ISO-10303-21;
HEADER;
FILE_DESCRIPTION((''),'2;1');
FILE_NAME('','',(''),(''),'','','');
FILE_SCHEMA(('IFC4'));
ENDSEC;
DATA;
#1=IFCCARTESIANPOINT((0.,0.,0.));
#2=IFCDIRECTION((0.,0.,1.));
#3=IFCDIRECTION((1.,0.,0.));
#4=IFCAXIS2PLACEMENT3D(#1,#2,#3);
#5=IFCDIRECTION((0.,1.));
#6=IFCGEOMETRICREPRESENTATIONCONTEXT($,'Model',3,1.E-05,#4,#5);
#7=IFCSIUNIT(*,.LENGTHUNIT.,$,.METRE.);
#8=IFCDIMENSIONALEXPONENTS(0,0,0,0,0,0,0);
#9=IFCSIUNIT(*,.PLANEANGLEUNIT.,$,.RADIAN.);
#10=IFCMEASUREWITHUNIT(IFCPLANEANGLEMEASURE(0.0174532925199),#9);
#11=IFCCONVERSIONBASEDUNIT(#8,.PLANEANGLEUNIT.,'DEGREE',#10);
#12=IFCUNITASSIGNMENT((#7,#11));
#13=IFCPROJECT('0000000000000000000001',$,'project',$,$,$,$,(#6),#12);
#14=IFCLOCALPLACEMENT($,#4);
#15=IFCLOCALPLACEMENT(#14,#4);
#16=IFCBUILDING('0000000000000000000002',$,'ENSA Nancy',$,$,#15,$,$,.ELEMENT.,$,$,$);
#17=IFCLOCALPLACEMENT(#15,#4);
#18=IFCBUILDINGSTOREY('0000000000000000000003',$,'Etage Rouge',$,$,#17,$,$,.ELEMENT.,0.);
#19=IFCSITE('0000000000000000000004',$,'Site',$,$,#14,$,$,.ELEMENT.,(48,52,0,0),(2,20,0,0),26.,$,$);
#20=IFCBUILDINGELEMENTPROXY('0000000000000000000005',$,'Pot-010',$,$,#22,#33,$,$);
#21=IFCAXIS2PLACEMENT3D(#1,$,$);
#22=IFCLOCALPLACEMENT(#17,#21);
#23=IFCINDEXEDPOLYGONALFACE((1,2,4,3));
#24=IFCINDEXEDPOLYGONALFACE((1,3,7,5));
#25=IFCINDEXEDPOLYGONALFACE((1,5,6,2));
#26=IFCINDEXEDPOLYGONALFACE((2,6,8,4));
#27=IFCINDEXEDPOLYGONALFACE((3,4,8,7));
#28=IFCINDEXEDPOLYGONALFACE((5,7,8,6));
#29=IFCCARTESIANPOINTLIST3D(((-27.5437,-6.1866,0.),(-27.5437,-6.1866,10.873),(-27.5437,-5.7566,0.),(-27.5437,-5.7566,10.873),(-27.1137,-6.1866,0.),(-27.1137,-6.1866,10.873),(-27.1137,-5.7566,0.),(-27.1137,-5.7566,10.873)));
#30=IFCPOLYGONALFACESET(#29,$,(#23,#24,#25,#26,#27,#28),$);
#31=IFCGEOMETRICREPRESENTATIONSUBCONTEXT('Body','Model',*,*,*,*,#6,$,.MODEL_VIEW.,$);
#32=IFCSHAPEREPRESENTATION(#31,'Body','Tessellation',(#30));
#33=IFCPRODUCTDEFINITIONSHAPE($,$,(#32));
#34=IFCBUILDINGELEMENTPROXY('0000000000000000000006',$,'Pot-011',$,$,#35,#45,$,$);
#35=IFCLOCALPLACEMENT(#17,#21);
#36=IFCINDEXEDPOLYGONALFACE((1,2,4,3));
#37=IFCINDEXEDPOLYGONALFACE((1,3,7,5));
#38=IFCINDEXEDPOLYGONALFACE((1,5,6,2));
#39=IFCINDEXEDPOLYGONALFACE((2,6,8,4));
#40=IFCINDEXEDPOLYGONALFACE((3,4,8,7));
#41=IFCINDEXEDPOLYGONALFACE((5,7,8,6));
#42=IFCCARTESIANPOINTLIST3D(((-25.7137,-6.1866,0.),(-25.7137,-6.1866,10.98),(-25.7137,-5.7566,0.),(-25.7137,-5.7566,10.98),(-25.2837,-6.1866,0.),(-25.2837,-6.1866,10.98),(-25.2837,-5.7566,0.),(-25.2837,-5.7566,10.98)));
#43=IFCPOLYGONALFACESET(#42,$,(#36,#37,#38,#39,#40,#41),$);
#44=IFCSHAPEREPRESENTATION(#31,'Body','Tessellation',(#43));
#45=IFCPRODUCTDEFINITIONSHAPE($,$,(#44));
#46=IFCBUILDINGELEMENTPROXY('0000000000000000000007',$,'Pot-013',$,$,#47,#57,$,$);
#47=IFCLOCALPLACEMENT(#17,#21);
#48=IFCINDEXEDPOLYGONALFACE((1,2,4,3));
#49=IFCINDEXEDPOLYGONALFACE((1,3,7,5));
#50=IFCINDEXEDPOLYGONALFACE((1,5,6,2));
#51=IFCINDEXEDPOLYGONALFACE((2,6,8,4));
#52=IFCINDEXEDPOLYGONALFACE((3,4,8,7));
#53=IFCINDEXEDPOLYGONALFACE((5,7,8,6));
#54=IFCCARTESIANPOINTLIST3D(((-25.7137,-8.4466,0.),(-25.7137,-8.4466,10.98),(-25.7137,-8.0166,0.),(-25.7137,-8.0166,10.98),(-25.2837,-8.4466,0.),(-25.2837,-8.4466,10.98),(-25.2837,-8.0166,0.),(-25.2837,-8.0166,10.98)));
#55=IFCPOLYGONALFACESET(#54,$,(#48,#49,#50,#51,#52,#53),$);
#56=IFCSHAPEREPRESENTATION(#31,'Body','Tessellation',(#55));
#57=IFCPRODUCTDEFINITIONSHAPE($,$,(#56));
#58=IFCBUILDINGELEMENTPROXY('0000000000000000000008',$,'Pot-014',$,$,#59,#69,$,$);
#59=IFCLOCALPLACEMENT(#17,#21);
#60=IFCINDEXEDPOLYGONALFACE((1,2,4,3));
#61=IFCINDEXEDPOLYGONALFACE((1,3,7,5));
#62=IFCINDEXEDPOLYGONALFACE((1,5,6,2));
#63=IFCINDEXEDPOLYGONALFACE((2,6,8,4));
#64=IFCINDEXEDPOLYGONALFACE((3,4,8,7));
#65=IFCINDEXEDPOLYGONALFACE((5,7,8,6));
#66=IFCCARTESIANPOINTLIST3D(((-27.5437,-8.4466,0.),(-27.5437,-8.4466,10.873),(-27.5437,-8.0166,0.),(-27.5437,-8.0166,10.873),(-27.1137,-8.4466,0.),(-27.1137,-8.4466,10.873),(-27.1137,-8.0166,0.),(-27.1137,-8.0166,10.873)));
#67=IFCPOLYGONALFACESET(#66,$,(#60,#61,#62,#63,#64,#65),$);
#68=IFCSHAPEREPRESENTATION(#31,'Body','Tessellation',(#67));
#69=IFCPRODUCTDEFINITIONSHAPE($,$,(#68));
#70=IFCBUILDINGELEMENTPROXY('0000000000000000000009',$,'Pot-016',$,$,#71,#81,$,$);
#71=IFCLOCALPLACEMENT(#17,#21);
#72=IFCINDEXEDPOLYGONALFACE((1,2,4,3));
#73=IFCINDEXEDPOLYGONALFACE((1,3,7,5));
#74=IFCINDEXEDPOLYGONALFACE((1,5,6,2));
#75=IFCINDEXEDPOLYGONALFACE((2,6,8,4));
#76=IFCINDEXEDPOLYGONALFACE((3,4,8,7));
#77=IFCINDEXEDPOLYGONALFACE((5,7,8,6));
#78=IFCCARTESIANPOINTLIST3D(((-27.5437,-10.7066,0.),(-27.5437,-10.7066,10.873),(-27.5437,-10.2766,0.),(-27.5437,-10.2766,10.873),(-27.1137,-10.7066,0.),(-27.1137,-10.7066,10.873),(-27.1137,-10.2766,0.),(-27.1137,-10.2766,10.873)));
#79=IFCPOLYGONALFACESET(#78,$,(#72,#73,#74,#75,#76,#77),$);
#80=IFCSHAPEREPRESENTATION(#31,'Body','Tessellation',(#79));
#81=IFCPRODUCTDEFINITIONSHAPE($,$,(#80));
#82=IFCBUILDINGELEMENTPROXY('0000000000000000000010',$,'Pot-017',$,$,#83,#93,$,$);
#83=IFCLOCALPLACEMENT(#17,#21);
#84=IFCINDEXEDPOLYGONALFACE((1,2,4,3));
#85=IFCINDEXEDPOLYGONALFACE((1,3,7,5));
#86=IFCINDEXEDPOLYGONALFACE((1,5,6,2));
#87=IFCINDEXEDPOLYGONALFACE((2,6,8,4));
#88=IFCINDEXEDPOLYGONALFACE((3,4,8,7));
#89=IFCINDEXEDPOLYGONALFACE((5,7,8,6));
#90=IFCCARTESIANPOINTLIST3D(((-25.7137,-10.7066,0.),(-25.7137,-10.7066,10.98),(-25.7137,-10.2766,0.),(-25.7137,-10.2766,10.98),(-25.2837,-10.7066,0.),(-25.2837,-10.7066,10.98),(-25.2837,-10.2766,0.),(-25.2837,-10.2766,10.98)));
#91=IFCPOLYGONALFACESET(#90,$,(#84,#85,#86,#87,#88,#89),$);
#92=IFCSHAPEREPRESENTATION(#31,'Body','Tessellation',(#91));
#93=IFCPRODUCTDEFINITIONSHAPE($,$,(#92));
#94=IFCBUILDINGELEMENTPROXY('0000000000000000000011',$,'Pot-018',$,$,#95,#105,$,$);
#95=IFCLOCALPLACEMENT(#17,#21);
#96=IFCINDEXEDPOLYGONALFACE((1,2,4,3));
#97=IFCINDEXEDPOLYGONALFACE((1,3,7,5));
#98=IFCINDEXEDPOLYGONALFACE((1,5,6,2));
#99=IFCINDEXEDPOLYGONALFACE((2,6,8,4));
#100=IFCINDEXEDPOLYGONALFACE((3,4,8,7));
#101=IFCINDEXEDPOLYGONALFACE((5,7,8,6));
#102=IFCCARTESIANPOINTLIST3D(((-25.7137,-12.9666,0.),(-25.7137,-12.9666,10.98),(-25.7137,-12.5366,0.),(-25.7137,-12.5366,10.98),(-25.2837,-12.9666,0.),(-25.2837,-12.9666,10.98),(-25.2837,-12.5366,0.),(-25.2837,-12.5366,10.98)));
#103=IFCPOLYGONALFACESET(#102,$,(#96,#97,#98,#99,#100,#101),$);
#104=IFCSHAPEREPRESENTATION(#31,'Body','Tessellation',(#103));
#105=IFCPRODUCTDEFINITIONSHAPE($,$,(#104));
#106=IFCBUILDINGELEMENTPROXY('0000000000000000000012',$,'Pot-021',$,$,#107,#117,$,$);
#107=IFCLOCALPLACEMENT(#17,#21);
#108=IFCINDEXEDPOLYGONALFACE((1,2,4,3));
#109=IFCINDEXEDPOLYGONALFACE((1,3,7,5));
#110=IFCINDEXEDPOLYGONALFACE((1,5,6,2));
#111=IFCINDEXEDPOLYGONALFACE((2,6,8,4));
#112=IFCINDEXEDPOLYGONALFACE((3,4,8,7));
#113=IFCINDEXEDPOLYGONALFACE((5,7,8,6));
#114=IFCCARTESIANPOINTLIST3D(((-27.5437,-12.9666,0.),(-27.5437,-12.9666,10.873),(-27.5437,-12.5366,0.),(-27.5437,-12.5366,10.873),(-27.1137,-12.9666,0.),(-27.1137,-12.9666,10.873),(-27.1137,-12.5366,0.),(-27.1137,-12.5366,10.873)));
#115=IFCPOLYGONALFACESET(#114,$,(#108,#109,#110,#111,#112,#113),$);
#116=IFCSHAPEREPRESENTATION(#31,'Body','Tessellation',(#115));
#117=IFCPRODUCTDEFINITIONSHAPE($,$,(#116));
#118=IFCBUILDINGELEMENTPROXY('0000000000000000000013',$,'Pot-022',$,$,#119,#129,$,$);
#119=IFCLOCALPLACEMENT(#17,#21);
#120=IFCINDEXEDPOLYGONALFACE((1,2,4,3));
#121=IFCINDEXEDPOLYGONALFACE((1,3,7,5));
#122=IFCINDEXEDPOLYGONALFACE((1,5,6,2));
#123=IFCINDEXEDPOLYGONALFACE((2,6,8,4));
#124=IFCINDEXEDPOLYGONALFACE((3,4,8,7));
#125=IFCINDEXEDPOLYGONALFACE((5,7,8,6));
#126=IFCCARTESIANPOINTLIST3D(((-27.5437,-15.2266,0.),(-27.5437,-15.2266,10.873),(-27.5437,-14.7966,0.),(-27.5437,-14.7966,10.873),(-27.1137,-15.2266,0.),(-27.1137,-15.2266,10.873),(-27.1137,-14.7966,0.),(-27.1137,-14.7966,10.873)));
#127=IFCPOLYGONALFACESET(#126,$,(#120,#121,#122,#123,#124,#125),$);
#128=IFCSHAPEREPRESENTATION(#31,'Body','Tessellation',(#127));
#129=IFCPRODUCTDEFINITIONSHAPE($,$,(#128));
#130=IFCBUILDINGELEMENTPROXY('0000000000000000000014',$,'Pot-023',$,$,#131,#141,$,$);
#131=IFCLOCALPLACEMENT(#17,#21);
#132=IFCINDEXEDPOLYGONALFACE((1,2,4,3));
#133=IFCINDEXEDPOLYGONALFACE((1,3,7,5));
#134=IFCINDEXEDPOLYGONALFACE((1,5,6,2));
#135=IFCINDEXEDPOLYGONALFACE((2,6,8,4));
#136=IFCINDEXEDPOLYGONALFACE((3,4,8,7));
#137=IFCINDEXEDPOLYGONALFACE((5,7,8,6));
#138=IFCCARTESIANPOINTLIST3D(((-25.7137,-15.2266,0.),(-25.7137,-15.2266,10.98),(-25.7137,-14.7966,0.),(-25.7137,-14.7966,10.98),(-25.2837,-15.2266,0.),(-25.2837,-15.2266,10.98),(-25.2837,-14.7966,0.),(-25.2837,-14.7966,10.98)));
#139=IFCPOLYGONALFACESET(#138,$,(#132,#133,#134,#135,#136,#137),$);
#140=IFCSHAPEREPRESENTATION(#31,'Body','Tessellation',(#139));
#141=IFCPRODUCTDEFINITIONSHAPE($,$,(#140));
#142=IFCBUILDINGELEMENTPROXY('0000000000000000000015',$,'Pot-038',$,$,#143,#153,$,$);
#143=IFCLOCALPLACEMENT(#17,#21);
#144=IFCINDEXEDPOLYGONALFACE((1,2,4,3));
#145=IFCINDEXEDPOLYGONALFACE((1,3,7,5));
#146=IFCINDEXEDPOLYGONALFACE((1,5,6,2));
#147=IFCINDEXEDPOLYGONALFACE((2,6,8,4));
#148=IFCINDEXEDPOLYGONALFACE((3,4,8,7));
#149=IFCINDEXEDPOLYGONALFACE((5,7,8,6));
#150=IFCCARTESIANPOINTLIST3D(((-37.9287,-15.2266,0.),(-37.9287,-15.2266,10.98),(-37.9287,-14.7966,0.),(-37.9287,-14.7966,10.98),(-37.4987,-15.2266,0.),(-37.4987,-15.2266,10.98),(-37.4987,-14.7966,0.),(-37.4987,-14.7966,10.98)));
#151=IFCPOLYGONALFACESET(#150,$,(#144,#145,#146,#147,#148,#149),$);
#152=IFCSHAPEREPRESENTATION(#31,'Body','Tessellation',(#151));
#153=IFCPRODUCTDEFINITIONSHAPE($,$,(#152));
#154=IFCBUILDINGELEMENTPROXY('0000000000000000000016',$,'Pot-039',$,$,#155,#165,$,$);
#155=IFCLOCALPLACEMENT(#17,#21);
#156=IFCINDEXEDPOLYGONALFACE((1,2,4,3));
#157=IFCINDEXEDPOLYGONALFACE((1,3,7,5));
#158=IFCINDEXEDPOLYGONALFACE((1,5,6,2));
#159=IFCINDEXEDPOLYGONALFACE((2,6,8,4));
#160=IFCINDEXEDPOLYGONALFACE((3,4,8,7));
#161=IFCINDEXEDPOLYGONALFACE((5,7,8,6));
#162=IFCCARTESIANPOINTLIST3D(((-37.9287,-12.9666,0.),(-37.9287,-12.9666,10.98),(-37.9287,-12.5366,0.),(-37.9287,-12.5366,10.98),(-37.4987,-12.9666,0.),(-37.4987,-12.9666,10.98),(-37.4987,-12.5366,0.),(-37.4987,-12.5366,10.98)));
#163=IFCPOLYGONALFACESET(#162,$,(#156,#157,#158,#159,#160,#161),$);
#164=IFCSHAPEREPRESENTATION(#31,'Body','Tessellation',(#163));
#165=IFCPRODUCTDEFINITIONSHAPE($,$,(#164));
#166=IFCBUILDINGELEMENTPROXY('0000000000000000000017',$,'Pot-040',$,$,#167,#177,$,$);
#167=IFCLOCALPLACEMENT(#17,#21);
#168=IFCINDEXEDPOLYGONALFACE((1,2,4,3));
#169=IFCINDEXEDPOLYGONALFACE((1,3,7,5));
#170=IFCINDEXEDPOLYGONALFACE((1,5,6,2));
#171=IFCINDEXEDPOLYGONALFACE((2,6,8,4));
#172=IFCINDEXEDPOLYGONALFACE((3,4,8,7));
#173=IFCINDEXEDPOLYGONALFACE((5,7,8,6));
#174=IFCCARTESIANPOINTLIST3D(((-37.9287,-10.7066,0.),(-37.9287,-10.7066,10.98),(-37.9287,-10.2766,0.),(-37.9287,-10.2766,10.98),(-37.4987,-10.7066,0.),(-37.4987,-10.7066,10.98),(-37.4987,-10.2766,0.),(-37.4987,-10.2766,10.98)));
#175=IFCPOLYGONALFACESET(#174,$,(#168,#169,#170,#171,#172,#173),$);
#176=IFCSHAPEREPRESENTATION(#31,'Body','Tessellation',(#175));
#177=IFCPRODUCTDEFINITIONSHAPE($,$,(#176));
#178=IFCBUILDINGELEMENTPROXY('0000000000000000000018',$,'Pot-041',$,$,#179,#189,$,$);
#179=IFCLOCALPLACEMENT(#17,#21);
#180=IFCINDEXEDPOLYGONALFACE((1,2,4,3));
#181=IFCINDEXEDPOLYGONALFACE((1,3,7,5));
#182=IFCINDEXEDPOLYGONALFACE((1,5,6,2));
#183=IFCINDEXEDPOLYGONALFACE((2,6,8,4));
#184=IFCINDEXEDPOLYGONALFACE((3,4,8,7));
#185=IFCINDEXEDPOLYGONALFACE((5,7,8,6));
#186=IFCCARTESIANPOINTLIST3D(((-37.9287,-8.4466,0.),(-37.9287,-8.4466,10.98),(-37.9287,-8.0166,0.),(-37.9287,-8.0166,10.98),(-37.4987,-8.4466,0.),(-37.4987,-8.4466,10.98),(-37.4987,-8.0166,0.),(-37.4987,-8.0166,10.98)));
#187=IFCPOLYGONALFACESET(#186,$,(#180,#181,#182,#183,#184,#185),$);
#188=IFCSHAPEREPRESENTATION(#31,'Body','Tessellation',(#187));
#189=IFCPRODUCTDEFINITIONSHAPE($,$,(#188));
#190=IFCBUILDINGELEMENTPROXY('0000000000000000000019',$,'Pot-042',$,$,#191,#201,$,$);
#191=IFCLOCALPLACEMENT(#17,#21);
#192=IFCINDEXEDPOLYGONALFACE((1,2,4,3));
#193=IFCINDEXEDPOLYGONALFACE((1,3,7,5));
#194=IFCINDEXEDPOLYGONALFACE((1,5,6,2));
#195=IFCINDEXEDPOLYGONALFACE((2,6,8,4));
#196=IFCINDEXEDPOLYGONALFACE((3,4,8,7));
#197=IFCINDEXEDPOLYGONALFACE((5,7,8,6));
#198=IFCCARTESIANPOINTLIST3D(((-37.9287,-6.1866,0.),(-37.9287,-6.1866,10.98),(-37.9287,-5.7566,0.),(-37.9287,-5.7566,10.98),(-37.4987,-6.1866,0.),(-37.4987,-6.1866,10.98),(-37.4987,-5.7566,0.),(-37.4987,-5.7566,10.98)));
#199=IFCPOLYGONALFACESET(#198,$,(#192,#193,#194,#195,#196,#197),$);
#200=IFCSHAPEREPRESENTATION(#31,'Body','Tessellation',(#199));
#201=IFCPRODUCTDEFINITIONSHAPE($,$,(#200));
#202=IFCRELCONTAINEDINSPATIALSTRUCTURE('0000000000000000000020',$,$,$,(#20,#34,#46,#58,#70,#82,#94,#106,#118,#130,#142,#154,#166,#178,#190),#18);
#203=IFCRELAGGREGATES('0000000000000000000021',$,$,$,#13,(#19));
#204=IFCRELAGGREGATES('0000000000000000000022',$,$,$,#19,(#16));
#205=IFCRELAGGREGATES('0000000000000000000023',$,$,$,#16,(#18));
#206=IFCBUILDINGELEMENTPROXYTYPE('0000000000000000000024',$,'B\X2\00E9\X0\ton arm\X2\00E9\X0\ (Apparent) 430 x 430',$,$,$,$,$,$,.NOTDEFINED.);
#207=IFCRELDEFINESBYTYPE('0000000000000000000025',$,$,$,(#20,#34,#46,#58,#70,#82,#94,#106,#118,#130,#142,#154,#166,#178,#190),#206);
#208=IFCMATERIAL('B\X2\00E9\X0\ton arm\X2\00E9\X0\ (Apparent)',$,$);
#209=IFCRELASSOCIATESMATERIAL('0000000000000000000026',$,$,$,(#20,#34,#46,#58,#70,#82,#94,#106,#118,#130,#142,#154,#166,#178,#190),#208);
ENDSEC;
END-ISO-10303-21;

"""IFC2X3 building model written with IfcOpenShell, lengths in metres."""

from ifc_helpers import new_model, entity, si_unit, converted_unit, direction, frame, origin_with_axes, origin_2d_with_axis, place, context, subcontext, project, spatial, rectangle, extrude, material, type_object, element, save


model = new_model("IFC2X3")

# Units and contexts
model_context = context("Model", 3, precision=1e-05, world=origin_with_axes(), true_north=direction((0.0, 1.0)))
body_context = subcontext(model_context, "Body", "Model", "MODEL_VIEW")
ifc_project = project(units=[si_unit("LENGTHUNIT", "METRE"), converted_unit("PLANEANGLEUNIT", "DEGREE", entity("IfcPlaneAngleMeasure", 0.0174532925199), si_unit("PLANEANGLEUNIT", "RADIAN"), dimensions=[0, 0, 0, 0, 0, 0, 0])], contexts=[model_context])

# Site, building, storey
site_placement = place(None, origin_with_axes())
site = spatial("IfcSite", under=ifc_project, at=site_placement, Name="Site", CompositionType="ELEMENT", RefLatitude=(48, 52, 0, 0), RefLongitude=(2, 20, 0, 0), RefElevation=26.0)
building_placement = place(site_placement, origin_with_axes())
building = spatial("IfcBuilding", under=site, at=building_placement, Name="ENSA Nancy", CompositionType="ELEMENT")
storey_placement = place(building_placement, origin_with_axes())
storey = spatial("IfcBuildingStorey", under=building, at=storey_placement, Name="Etage Rouge", CompositionType="ELEMENT", Elevation=0.0)

# Building element proxies
ifc_material_1 = material(Name="Béton armé (Apparent)")
building_element_proxy_type_1 = type_object("IfcBuildingElementProxyType", Name="Béton armé (Apparent) 430 x 430", PredefinedType="NOTDEFINED")
proxy_1_placement = place(storey_placement, frame((-27.3287, -5.9716, 0.0), z_axis=(0.0, 0.0, 1.0), x_axis=(1.0, 0.0, 0.0)))
element("IfcBuildingElementProxy", 1, at=proxy_1_placement, inside=storey, type_object=building_element_proxy_type_1, material=ifc_material_1, Name="Pot-010", context=body_context, shape_type="SweptSolid", body=[
    extrude(rectangle(XDim=0.43, YDim=0.43, at=origin_2d_with_axis()), origin_with_axes(), (0.0, 0.0, 1.0), 10.873),
])
for number, where, z_axis, x_axis, name in (
    (2, (-25.4987, -5.9716, 0.0), (0.0, 0.0, 1.0), (1.0, 0.0, 0.0), "Pot-011"),
    (3, (-25.4987, -8.2316, 0.0), (0.0, 0.0, 1.0), (1.0, 0.0, 0.0), "Pot-013"),
):
    element("IfcBuildingElementProxy", number, at=place(storey_placement, frame(where, z_axis=z_axis, x_axis=x_axis)), inside=storey, type_object=building_element_proxy_type_1, material=ifc_material_1, Name=name, context=body_context, shape_type="SweptSolid", body=[
        extrude(rectangle(XDim=0.43, YDim=0.43, at=origin_2d_with_axis()), origin_with_axes(), (0.0, 0.0, 1.0), 10.98),
    ])
for number, where, z_axis, x_axis, name in (
    (4, (-27.3287, -8.2316, 0.0), (0.0, 0.0, 1.0), (1.0, 0.0, 0.0), "Pot-014"),
    (5, (-27.3287, -10.4916, 0.0), (0.0, 0.0, 1.0), (1.0, 0.0, 0.0), "Pot-016"),
):
    element("IfcBuildingElementProxy", number, at=place(storey_placement, frame(where, z_axis=z_axis, x_axis=x_axis)), inside=storey, type_object=building_element_proxy_type_1, material=ifc_material_1, Name=name, context=body_context, shape_type="SweptSolid", body=[
        extrude(rectangle(XDim=0.43, YDim=0.43, at=origin_2d_with_axis()), origin_with_axes(), (0.0, 0.0, 1.0), 10.873),
    ])
for number, where, z_axis, x_axis, name in (
    (6, (-25.4987, -10.4916, 0.0), (0.0, 0.0, 1.0), (1.0, 0.0, 0.0), "Pot-017"),
    (7, (-25.4987, -12.7516, 0.0), (0.0, 0.0, 1.0), (1.0, 0.0, 0.0), "Pot-018"),
):
    element("IfcBuildingElementProxy", number, at=place(storey_placement, frame(where, z_axis=z_axis, x_axis=x_axis)), inside=storey, type_object=building_element_proxy_type_1, material=ifc_material_1, Name=name, context=body_context, shape_type="SweptSolid", body=[
        extrude(rectangle(XDim=0.43, YDim=0.43, at=origin_2d_with_axis()), origin_with_axes(), (0.0, 0.0, 1.0), 10.98),
    ])
for number, where, z_axis, x_axis, name in (
    (8, (-27.3287, -12.7516, 0.0), (0.0, 0.0, 1.0), (1.0, 0.0, 0.0), "Pot-021"),
    (9, (-27.3287, -15.0116, 0.0), (0.0, 0.0, 1.0), (1.0, 0.0, 0.0), "Pot-022"),
):
    element("IfcBuildingElementProxy", number, at=place(storey_placement, frame(where, z_axis=z_axis, x_axis=x_axis)), inside=storey, type_object=building_element_proxy_type_1, material=ifc_material_1, Name=name, context=body_context, shape_type="SweptSolid", body=[
        extrude(rectangle(XDim=0.43, YDim=0.43, at=origin_2d_with_axis()), origin_with_axes(), (0.0, 0.0, 1.0), 10.873),
    ])
for number, where, z_axis, x_axis, name in (
    (10, (-25.4987, -15.0116, 0.0), (0.0, 0.0, 1.0), (1.0, 0.0, 0.0), "Pot-023"),
    (11, (-37.7137, -15.0116, 0.0), (0.0, 0.0, 1.0), (1.0, 0.0, 0.0), "Pot-038"),
    (12, (-37.7137, -12.7516, 0.0), (0.0, 0.0, 1.0), (1.0, 0.0, 0.0), "Pot-039"),
    (13, (-37.7137, -10.4916, 0.0), (0.0, 0.0, 1.0), (1.0, 0.0, 0.0), "Pot-040"),
    (14, (-37.7137, -8.2316, 0.0), (0.0, 0.0, 1.0), (1.0, 0.0, 0.0), "Pot-041"),
    (15, (-37.7137, -5.9716, 0.0), (0.0, 0.0, 1.0), (1.0, 0.0, 0.0), "Pot-042"),
):
    element("IfcBuildingElementProxy", number, at=place(storey_placement, frame(where, z_axis=z_axis, x_axis=x_axis)), inside=storey, type_object=building_element_proxy_type_1, material=ifc_material_1, Name=name, context=body_context, shape_type="SweptSolid", body=[
        extrude(rectangle(XDim=0.43, YDim=0.43, at=origin_2d_with_axis()), origin_with_axes(), (0.0, 0.0, 1.0), 10.98),
    ])

save(model, "model.ifc")
